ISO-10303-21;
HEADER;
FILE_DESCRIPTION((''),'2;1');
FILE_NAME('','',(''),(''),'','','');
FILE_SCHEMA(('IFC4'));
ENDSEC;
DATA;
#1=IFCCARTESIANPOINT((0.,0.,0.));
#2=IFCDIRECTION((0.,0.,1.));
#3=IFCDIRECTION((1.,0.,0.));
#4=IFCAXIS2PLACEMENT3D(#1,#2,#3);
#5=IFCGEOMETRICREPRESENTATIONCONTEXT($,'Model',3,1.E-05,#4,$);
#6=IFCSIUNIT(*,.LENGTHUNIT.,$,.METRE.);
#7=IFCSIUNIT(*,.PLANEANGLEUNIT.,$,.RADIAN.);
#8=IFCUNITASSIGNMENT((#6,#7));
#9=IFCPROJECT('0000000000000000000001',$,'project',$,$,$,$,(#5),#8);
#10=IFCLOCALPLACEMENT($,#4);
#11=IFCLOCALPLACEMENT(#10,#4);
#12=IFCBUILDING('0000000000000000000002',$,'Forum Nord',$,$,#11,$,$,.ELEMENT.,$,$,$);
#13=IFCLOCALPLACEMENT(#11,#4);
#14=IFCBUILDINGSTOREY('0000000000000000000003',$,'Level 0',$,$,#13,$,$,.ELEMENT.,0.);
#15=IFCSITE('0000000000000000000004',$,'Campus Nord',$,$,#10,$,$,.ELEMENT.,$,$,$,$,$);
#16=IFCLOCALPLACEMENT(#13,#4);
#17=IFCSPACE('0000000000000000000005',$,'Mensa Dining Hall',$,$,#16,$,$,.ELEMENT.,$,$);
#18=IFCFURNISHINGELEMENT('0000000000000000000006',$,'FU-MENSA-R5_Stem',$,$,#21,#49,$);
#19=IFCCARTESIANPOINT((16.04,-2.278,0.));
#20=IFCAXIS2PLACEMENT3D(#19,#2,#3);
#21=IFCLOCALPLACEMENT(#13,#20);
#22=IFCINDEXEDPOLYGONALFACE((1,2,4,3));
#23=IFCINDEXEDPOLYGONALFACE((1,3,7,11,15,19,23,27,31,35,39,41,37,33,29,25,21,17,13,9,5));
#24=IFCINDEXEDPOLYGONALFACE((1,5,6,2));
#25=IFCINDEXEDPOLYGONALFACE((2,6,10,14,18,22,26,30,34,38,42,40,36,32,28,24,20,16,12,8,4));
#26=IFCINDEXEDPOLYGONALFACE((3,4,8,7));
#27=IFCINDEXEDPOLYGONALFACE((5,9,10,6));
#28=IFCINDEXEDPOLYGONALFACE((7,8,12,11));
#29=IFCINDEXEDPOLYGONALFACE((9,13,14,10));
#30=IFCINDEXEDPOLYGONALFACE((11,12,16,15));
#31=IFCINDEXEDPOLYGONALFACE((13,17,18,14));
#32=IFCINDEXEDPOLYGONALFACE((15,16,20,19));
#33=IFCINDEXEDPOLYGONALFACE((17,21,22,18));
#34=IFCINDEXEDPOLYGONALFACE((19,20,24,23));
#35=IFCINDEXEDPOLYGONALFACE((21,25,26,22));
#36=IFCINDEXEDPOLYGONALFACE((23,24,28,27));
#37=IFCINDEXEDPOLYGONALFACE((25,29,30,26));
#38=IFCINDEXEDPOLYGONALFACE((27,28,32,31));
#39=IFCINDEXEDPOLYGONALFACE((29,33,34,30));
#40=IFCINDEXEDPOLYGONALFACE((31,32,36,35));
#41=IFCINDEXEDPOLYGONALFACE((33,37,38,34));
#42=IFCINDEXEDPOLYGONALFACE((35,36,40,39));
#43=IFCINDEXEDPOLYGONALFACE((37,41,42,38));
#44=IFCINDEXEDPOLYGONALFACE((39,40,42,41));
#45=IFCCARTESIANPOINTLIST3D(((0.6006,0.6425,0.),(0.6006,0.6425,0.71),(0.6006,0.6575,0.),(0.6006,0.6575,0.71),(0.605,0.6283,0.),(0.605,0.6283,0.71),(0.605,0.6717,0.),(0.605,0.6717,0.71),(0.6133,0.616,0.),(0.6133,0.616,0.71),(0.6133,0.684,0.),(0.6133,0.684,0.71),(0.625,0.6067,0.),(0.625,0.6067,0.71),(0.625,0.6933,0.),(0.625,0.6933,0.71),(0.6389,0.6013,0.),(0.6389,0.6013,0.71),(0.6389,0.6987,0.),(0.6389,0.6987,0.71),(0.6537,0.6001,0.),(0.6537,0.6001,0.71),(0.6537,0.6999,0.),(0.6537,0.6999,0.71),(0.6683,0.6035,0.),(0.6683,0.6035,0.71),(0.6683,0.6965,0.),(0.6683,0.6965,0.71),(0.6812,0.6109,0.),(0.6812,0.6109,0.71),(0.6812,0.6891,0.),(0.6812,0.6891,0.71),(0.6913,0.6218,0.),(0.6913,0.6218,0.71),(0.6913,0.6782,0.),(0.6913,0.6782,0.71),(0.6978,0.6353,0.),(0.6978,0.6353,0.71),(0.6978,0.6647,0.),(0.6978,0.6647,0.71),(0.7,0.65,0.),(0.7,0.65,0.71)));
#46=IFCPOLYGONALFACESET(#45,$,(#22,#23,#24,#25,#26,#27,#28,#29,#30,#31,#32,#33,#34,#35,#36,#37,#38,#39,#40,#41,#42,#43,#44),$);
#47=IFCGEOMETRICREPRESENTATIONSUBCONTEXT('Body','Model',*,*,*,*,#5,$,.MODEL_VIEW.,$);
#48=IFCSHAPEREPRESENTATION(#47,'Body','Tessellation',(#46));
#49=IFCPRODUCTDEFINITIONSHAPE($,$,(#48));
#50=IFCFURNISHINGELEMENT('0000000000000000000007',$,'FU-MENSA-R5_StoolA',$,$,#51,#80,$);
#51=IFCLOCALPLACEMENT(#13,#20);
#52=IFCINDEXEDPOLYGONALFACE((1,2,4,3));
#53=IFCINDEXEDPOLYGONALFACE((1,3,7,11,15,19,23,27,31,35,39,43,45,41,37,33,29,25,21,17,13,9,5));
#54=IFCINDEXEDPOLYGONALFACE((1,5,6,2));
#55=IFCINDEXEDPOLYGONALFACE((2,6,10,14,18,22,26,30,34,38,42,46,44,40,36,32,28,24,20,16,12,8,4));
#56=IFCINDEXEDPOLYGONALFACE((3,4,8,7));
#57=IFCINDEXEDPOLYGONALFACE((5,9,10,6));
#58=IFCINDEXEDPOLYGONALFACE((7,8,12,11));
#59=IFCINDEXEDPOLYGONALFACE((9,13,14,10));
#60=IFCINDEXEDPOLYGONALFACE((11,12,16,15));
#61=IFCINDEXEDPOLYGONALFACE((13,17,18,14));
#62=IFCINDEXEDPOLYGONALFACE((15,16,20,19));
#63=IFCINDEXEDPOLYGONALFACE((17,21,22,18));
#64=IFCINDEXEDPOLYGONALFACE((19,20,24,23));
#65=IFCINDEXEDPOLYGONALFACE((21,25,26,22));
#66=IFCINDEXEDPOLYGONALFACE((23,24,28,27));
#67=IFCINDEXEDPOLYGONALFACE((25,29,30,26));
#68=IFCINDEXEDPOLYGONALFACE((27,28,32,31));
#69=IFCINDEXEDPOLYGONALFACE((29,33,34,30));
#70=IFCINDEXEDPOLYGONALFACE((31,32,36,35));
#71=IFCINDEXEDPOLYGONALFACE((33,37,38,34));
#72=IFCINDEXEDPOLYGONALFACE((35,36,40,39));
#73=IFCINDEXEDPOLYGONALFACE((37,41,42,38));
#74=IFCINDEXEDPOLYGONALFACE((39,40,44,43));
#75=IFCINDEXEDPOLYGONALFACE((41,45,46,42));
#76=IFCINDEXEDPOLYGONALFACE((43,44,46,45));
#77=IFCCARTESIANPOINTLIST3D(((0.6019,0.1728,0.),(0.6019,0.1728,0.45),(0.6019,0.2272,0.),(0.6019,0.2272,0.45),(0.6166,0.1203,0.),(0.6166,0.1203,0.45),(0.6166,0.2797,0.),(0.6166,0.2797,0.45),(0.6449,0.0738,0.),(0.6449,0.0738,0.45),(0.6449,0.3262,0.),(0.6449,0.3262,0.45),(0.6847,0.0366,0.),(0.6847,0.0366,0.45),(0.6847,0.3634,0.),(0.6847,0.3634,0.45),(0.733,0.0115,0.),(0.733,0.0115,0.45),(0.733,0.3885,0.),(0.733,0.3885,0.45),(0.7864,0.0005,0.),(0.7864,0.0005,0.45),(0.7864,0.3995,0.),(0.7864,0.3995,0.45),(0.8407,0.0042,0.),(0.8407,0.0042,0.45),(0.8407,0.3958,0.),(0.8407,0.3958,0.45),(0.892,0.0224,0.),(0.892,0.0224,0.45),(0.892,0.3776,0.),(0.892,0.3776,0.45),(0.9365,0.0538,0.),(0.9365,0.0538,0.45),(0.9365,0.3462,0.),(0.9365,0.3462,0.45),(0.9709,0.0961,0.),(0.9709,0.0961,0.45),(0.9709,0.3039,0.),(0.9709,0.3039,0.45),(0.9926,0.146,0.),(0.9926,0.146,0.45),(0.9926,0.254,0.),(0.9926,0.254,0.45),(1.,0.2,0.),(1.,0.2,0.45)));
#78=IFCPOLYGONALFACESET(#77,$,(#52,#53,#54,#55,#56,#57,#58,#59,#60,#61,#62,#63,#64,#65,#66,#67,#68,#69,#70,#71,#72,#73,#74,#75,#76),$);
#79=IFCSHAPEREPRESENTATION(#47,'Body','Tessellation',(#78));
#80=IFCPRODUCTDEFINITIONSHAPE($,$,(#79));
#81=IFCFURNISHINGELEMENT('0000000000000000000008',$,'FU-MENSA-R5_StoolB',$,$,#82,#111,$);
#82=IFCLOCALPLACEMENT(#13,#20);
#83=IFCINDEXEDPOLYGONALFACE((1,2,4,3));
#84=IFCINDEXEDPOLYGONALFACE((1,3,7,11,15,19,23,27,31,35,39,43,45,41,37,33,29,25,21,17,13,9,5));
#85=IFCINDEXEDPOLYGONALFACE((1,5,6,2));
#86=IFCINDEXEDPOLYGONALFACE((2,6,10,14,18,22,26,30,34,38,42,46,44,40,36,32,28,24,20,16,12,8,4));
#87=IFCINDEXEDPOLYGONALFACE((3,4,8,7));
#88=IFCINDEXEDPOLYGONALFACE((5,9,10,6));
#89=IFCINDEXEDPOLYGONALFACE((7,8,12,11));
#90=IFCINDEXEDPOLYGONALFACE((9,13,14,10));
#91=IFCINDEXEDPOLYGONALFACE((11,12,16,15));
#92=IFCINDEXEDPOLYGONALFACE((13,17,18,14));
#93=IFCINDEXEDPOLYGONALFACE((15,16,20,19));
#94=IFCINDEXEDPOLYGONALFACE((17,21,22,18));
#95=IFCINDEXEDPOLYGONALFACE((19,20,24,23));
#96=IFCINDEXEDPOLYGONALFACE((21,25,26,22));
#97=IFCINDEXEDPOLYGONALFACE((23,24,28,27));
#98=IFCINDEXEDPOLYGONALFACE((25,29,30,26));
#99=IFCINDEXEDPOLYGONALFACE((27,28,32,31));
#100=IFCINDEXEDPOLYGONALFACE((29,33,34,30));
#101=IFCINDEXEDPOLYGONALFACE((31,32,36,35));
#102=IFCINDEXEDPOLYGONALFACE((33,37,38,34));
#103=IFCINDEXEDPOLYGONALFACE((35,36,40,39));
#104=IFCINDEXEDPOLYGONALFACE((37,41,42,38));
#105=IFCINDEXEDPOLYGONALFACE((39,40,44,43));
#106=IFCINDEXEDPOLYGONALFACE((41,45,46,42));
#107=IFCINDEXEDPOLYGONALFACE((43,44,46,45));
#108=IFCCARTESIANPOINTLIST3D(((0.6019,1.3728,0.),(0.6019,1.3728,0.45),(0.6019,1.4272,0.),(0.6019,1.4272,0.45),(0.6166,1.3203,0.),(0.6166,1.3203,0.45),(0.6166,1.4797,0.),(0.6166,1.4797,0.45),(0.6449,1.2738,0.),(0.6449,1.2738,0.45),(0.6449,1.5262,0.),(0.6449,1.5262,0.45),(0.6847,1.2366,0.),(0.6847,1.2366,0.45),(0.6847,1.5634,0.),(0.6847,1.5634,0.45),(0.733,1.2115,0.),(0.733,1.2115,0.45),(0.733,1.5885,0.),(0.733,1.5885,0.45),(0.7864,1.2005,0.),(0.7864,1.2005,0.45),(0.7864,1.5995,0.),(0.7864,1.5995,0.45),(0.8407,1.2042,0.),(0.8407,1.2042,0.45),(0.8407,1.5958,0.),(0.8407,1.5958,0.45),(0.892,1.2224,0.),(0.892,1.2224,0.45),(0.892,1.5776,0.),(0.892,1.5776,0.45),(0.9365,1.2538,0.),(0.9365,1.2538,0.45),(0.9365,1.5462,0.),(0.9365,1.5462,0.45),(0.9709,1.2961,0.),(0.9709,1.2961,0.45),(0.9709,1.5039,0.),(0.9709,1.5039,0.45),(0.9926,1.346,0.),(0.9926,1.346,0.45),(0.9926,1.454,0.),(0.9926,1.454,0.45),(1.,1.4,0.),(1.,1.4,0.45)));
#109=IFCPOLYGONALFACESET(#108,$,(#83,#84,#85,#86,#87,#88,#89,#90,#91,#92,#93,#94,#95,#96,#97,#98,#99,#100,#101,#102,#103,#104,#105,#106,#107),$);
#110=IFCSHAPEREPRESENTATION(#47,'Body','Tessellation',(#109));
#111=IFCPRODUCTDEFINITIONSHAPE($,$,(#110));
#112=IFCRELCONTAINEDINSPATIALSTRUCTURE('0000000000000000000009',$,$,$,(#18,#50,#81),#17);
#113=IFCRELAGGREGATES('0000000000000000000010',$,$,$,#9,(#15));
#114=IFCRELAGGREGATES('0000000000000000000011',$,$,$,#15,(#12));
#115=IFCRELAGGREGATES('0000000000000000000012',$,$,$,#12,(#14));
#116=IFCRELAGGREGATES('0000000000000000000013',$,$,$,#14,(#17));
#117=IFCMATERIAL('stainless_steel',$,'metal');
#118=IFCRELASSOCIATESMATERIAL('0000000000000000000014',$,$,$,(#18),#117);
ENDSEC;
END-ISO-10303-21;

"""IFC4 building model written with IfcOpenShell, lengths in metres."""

from ifc_helpers import new_model, si_unit, frame, frame_2d, origin_with_axes, place, context, subcontext, project, spatial, circle, extrude, material, element, save


model = new_model("IFC4")

# Units and contexts
model_context = context("Model", 3, precision=1e-05, world=origin_with_axes())
body_context = subcontext(model_context, "Body", "Model", "MODEL_VIEW")
ifc_project = project(units=[si_unit("LENGTHUNIT", "METRE"), si_unit("PLANEANGLEUNIT", "RADIAN")], contexts=[model_context])

# Site, building, storey, space
site_placement = place(None, origin_with_axes())
site = spatial("IfcSite", under=ifc_project, at=site_placement, Name="Campus Nord", CompositionType="ELEMENT")
building_placement = place(site_placement, origin_with_axes())
building = spatial("IfcBuilding", under=site, at=building_placement, Name="Forum Nord", CompositionType="ELEMENT")
storey_placement = place(building_placement, origin_with_axes())
storey = spatial("IfcBuildingStorey", under=building, at=storey_placement, Name="Level 0", CompositionType="ELEMENT", Elevation=0.0)
space_placement = place(storey_placement, origin_with_axes())
space = spatial("IfcSpace", under=storey, at=space_placement, Name="Mensa Dining Hall", CompositionType="ELEMENT")

# Furnishing elements
ifc_material_1 = material(Name="stainless_steel", Category="metal")
furnishing_1_placement = place(storey_placement, frame((16.04, -2.278, 0.0), z_axis=(0.0, 0.0, 1.0), x_axis=(1.0, 0.0, 0.0)))
element("IfcFurnishingElement", 1, at=furnishing_1_placement, inside=space, material=ifc_material_1, Name="FU-MENSA-R5_Stem", context=body_context, shape_type="SweptSolid", body=[
    extrude(circle(Radius=0.05, at=frame_2d((0.65, 0.65), x_axis=(1.0, 0.0))), origin_with_axes(), (0.0, 0.0, 1.0), 0.71),
])
furnishing_2_placement = place(storey_placement, frame((16.04, -2.278, 0.0), z_axis=(0.0, 0.0, 1.0), x_axis=(1.0, 0.0, 0.0)))
element("IfcFurnishingElement", 2, at=furnishing_2_placement, inside=space, Name="FU-MENSA-R5_StoolA", context=body_context, shape_type="SweptSolid", body=[
    extrude(circle(Radius=0.2, at=frame_2d((0.8, 0.2), x_axis=(1.0, 0.0))), origin_with_axes(), (0.0, 0.0, 1.0), 0.45),
])
furnishing_3_placement = place(storey_placement, frame((16.04, -2.278, 0.0), z_axis=(0.0, 0.0, 1.0), x_axis=(1.0, 0.0, 0.0)))
element("IfcFurnishingElement", 3, at=furnishing_3_placement, inside=space, Name="FU-MENSA-R5_StoolB", context=body_context, shape_type="SweptSolid", body=[
    extrude(circle(Radius=0.2, at=frame_2d((0.8, 1.4), x_axis=(1.0, 0.0))), origin_with_axes(), (0.0, 0.0, 1.0), 0.45),
])

save(model, "model.ifc")
